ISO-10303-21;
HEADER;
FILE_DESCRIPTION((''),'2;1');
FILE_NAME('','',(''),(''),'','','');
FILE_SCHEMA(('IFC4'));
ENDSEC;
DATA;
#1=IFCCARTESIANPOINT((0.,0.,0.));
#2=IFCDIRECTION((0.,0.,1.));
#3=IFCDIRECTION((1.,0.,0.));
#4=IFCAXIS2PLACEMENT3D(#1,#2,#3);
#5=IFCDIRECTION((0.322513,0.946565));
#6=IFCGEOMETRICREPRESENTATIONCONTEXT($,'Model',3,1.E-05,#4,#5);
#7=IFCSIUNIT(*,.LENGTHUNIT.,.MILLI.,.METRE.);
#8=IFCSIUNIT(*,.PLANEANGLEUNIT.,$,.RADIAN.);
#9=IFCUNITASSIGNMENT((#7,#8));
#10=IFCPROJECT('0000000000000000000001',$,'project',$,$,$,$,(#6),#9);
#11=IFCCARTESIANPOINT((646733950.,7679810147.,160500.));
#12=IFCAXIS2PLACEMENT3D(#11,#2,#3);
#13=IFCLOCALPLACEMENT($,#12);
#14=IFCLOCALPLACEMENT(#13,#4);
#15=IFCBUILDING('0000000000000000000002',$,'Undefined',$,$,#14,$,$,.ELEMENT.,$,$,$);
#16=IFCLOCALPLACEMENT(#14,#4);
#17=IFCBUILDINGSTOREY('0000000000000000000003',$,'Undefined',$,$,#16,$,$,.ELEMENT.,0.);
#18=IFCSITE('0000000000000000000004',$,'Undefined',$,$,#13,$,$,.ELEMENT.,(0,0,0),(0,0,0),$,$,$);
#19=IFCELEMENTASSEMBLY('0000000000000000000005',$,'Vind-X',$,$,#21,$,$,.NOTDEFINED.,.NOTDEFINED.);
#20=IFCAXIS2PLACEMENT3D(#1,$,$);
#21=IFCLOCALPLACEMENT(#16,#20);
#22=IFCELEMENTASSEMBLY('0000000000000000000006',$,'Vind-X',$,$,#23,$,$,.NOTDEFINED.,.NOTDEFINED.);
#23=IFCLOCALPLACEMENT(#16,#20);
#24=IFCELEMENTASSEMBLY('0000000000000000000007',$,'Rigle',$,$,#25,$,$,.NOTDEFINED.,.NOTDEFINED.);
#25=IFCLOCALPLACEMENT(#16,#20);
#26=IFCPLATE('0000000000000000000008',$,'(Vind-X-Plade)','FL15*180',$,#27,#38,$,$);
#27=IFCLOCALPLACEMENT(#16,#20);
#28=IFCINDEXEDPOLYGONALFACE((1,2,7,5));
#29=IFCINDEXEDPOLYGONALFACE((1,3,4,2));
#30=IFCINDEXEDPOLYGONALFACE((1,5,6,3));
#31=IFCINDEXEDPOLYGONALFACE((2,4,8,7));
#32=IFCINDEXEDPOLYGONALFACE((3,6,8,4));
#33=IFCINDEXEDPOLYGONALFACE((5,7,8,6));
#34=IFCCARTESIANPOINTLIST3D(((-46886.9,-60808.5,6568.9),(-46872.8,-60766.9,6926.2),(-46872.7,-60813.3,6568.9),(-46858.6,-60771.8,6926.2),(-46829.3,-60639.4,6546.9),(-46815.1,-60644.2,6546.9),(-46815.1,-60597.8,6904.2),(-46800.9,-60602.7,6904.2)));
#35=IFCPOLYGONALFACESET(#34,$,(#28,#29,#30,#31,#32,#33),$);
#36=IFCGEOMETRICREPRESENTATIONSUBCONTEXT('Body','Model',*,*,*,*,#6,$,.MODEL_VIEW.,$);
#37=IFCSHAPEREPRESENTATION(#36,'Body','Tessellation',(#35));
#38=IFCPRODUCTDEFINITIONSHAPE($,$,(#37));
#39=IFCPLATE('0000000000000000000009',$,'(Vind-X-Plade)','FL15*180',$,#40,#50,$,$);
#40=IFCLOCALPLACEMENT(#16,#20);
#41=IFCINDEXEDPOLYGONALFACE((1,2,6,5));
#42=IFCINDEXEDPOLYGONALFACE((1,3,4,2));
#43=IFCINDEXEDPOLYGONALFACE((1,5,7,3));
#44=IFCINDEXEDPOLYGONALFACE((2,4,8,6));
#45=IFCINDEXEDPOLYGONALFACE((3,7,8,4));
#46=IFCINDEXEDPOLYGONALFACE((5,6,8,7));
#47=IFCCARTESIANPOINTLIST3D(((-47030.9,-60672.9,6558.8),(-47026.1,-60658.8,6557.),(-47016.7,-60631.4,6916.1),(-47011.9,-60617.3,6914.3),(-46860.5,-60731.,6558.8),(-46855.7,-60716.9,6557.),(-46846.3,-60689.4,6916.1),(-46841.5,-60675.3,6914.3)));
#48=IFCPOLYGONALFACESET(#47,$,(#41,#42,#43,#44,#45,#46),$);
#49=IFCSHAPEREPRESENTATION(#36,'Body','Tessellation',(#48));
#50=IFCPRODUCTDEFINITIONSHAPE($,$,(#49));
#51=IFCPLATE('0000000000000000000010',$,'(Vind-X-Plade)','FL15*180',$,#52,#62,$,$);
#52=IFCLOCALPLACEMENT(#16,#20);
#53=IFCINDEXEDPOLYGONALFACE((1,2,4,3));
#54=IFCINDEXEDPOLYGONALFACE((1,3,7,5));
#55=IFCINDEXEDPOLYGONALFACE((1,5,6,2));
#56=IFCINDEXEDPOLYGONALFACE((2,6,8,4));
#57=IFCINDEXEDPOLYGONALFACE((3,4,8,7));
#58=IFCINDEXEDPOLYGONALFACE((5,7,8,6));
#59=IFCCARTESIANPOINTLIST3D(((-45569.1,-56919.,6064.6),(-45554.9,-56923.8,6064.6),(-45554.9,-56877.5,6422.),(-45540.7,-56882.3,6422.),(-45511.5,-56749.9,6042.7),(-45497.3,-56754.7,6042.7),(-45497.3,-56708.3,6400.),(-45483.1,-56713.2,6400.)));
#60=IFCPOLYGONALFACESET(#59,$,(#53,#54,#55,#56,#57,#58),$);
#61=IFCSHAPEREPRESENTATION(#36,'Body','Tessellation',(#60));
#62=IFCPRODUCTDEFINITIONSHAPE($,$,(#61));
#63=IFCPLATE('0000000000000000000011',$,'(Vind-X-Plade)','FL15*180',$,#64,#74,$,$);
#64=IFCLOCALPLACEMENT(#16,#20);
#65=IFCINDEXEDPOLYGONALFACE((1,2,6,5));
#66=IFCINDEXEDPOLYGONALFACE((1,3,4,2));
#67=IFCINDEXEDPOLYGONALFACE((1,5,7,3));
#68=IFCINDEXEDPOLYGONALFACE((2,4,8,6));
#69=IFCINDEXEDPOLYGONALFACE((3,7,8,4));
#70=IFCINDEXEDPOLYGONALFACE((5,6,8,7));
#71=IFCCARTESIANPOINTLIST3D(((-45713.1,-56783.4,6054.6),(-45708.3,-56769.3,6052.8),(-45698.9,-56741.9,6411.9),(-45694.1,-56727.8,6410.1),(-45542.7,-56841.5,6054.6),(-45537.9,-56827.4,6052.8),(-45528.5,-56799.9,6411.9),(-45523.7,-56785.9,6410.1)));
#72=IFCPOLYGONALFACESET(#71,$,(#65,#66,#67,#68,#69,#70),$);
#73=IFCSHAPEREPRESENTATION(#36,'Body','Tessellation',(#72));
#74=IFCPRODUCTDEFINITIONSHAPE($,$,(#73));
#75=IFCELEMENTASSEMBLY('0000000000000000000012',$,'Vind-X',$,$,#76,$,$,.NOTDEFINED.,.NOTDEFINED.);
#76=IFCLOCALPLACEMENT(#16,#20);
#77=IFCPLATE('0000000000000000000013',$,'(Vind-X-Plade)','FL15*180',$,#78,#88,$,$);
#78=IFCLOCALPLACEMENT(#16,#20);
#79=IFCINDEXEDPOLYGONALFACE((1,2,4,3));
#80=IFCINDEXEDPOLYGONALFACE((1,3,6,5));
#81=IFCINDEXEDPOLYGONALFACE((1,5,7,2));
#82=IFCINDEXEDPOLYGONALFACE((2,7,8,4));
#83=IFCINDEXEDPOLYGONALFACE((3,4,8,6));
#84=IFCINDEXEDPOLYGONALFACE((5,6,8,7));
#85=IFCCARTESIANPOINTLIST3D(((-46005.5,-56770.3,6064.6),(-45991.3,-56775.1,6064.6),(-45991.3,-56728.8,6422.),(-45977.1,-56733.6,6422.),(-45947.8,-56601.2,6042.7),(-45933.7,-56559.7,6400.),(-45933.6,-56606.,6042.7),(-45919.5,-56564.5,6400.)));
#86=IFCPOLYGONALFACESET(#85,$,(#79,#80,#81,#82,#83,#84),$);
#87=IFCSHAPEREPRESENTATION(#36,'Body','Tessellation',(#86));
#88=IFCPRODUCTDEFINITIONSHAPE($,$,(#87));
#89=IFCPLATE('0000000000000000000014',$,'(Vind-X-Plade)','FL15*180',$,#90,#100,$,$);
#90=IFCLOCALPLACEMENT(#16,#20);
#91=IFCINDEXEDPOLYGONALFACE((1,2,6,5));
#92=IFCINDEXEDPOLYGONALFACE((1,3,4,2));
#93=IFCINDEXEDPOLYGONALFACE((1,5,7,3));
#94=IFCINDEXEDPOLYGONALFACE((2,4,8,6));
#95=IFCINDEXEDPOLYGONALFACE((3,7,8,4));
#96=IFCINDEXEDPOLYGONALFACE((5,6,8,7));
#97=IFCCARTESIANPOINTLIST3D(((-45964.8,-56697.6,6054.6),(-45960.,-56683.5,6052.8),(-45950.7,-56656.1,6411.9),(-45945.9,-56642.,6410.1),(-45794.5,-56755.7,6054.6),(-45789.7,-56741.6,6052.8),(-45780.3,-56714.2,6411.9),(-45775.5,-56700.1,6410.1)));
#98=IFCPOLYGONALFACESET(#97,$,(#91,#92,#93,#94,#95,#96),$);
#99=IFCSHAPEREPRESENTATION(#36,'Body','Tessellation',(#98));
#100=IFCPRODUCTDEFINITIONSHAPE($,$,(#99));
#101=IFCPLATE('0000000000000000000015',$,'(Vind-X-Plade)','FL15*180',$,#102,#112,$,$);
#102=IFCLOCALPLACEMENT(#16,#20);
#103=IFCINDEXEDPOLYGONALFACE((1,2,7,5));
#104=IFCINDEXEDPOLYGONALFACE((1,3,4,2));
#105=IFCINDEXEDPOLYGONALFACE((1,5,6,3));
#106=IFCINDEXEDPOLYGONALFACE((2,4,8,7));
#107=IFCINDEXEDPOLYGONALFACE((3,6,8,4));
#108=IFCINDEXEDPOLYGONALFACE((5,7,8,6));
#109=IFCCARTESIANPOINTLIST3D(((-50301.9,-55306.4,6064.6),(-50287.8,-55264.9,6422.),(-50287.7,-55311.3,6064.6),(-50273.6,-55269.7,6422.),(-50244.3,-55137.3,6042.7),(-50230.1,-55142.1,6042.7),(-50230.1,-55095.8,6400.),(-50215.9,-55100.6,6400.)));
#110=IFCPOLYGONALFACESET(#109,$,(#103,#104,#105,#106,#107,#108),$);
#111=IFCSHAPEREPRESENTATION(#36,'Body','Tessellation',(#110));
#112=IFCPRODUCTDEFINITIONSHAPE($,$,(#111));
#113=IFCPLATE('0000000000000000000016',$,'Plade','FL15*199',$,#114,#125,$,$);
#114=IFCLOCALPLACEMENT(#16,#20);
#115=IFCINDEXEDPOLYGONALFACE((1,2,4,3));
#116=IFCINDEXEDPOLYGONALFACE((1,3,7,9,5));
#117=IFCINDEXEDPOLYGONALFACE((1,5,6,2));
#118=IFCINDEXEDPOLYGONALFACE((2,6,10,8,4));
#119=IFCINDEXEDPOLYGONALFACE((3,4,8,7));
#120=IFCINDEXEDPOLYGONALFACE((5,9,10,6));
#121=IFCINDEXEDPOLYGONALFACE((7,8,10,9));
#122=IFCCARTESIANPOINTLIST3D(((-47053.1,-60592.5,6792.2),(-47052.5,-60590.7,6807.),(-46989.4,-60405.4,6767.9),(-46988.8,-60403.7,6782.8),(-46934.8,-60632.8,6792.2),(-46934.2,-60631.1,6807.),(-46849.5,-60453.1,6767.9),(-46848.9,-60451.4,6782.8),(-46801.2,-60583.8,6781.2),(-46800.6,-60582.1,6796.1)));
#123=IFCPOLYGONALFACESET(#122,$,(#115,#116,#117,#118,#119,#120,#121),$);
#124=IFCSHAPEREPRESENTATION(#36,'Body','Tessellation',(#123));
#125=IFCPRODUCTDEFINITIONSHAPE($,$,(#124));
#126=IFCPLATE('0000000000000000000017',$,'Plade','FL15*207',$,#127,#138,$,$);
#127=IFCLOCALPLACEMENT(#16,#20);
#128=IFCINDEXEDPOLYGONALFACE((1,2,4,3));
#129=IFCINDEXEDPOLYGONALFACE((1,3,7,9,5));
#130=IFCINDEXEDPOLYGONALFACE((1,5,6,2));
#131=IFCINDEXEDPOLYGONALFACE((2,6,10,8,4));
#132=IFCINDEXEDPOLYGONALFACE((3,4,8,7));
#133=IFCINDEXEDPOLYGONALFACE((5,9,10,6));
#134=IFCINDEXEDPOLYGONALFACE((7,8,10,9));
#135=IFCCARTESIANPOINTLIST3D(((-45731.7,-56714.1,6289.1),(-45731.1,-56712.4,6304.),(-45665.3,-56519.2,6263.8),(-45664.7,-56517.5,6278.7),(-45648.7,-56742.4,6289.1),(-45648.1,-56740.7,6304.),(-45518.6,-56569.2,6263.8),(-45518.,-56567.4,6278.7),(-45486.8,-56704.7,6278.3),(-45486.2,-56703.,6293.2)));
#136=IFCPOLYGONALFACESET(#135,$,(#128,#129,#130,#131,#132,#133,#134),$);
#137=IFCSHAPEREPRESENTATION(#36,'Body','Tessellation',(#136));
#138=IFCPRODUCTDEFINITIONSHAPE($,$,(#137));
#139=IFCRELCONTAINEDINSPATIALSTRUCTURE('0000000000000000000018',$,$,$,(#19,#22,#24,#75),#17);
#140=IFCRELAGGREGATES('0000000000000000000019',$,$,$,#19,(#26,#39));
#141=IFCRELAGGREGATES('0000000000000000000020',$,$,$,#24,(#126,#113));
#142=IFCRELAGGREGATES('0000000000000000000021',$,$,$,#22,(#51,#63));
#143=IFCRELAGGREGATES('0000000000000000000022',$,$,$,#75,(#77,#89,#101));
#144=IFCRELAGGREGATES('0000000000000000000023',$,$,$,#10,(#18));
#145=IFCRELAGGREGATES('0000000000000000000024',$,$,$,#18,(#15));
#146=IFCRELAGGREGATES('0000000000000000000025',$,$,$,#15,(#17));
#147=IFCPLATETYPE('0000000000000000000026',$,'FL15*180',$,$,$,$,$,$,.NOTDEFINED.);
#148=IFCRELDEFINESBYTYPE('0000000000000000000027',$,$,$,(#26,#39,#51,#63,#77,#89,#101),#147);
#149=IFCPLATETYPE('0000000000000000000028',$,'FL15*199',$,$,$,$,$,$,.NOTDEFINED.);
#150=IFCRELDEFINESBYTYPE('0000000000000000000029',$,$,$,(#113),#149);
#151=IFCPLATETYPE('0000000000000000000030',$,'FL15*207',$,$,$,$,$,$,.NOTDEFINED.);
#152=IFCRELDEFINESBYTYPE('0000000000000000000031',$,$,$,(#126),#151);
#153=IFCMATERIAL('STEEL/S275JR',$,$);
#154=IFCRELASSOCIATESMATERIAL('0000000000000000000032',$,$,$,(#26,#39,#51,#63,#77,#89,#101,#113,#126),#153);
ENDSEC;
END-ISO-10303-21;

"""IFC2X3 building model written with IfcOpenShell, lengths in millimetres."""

from ifc_helpers import new_model, si_unit, direction, frame, origin_with_axes, place, context, subcontext, project, spatial, polyline, outline, extrude, material, type_object, element, aggregate, save


model = new_model("IFC2X3")

# Units and contexts
model_context = context("Model", 3, precision=1e-05, world=origin_with_axes(), true_north=direction((0.322513, 0.946565)))
body_context = subcontext(model_context, "Body", "Model", "MODEL_VIEW")
ifc_project = project(units=[si_unit("LENGTHUNIT", "METRE", prefix="MILLI"), si_unit("PLANEANGLEUNIT", "RADIAN")], contexts=[model_context])

# Site, building, storey
site_placement = place(None, frame((646733950.0, 7679810147.0, 160500.0), z_axis=(0.0, 0.0, 1.0), x_axis=(1.0, 0.0, 0.0)))
site = spatial("IfcSite", under=ifc_project, at=site_placement, Name="Undefined", CompositionType="ELEMENT", RefLatitude=(0, 0, 0), RefLongitude=(0, 0, 0))
building_placement = place(site_placement, origin_with_axes())
building = spatial("IfcBuilding", under=site, at=building_placement, Name="Undefined", CompositionType="ELEMENT")
storey_placement = place(building_placement, origin_with_axes())
storey = spatial("IfcBuildingStorey", under=building, at=storey_placement, Name="Undefined", CompositionType="ELEMENT", Elevation=0.0)

# Element assemblies
assembly_1_placement = place(storey_placement, origin_with_axes())
assembly_1 = element("IfcElementAssembly", 1, at=assembly_1_placement, inside=storey, Name="Vind-X", AssemblyPlace="NOTDEFINED", PredefinedType="NOTDEFINED")
assembly_2_placement = place(storey_placement, origin_with_axes())
assembly_2 = element("IfcElementAssembly", 2, at=assembly_2_placement, inside=storey, Name="Vind-X", AssemblyPlace="NOTDEFINED", PredefinedType="NOTDEFINED")

# Element assembly
assembly_3_placement = place(storey_placement, origin_with_axes())
assembly_3 = element("IfcElementAssembly", 3, at=assembly_3_placement, inside=storey, Name="Rigle", AssemblyPlace="NOTDEFINED", PredefinedType="NOTDEFINED")

# Shared definitions
ifc_material_1 = material(Name="STEEL/S275JR")

# Plates
plate_type_1 = type_object("IfcPlateType", Name="FL15*180", PredefinedType="NOTDEFINED")
plate_1_placement = place(assembly_1_placement, frame((-46865.7, -60769.4, 6926.2), z_axis=(-0.946565, 0.322513, 0.0), x_axis=(0.320109, 0.93951, -0.121869)))
plate_1 = element("IfcPlate", 4, at=plate_1_placement, type_object=plate_type_1, material=ifc_material_1, Name="(Vind-X-Plade)", Description="FL15*180", context=body_context, shape_type="SweptSolid", body=[
    extrude(outline(polyline([(0.0, 0.0), (180.0, 0.0), (180.0, 360.0), (0.0, 360.0), (0.0, 0.0)])), frame((0.0, 0.0, -7.5), z_axis=(0.0, 0.0, 1.0), x_axis=(1.0, 0.0, 0.0)), (0.0, 0.0, 1.0), 15.0),
])
plate_2_placement = place(assembly_1_placement, frame((-47028.5, -60665.9, 6557.9), z_axis=(0.320109, 0.93951, -0.121869), x_axis=(0.039304, 0.115357, 0.992546)))
plate_2 = element("IfcPlate", 5, at=plate_2_placement, type_object=plate_type_1, material=ifc_material_1, Name="(Vind-X-Plade)", Description="FL15*180", context=body_context, shape_type="SweptSolid", body=[
    extrude(outline(polyline([(0.0, 0.0), (360.0, 0.0), (360.0, 180.0), (0.0, 180.0), (0.0, 0.0)])), frame((0.0, 0.0, -7.5), z_axis=(0.0, 0.0, 1.0), x_axis=(1.0, 0.0, 0.0)), (0.0, 0.0, 1.0), 15.0),
])
plate_3_placement = place(assembly_2_placement, frame((-45547.8, -56879.9, 6422.0), z_axis=(-0.946565, 0.322513, 0.0), x_axis=(0.320109, 0.93951, -0.121869)))
plate_3 = element("IfcPlate", 6, at=plate_3_placement, type_object=plate_type_1, material=ifc_material_1, Name="(Vind-X-Plade)", Description="FL15*180", context=body_context, shape_type="SweptSolid", body=[
    extrude(outline(polyline([(0.0, 0.0), (180.0, 0.0), (180.0, 360.0), (0.0, 360.0), (0.0, 0.0)])), frame((0.0, 0.0, -7.5), z_axis=(0.0, 0.0, 1.0), x_axis=(1.0, 0.0, 0.0)), (0.0, 0.0, 1.0), 15.0),
])
plate_4_placement = place(assembly_2_placement, frame((-45710.7, -56776.4, 6053.7), z_axis=(0.320109, 0.93951, -0.121869), x_axis=(0.039304, 0.115357, 0.992546)))
plate_4 = element("IfcPlate", 7, at=plate_4_placement, type_object=plate_type_1, material=ifc_material_1, Name="(Vind-X-Plade)", Description="FL15*180", context=body_context, shape_type="SweptSolid", body=[
    extrude(outline(polyline([(0.0, 0.0), (360.0, 0.0), (360.0, 180.0), (0.0, 180.0), (0.0, 0.0)])), frame((0.0, 0.0, -7.5), z_axis=(0.0, 0.0, 1.0), x_axis=(1.0, 0.0, 0.0)), (0.0, 0.0, 1.0), 15.0),
])

# Element assembly, plates
assembly_4_placement = place(storey_placement, origin_with_axes())
assembly_4 = element("IfcElementAssembly", 8, at=assembly_4_placement, inside=storey, Name="Vind-X", AssemblyPlace="NOTDEFINED", PredefinedType="NOTDEFINED")
plate_5_placement = place(assembly_4_placement, frame((-45926.6, -56562.1, 6400.0), z_axis=(0.946565, -0.322513, 0.0), x_axis=(-0.320109, -0.93951, 0.121869)))
plate_5 = element("IfcPlate", 9, at=plate_5_placement, type_object=plate_type_1, material=ifc_material_1, Name="(Vind-X-Plade)", Description="FL15*180", context=body_context, shape_type="SweptSolid", body=[
    extrude(outline(polyline([(0.0, 0.0), (180.0, 0.0), (180.0, 360.0), (0.0, 360.0), (0.0, 0.0)])), frame((0.0, 0.0, -7.5), z_axis=(0.0, 0.0, 1.0), x_axis=(1.0, 0.0, 0.0)), (0.0, 0.0, 1.0), 15.0),
])
plate_6_placement = place(assembly_4_placement, frame((-45792.1, -56748.6, 6053.7), z_axis=(-0.320109, -0.93951, 0.121869), x_axis=(0.039304, 0.115357, 0.992546)))
plate_6 = element("IfcPlate", 10, at=plate_6_placement, type_object=plate_type_1, material=ifc_material_1, Name="(Vind-X-Plade)", Description="FL15*180", context=body_context, shape_type="SweptSolid", body=[
    extrude(outline(polyline([(0.0, 0.0), (360.0, 0.0), (360.0, 180.0), (0.0, 180.0), (0.0, 0.0)])), frame((0.0, 0.0, -7.5), z_axis=(0.0, 0.0, 1.0), x_axis=(1.0, 0.0, 0.0)), (0.0, 0.0, 1.0), 15.0),
])
plate_7_placement = place(assembly_4_placement, frame((-50280.7, -55267.3, 6422.0), z_axis=(-0.946565, 0.322513, 0.0), x_axis=(0.320109, 0.93951, -0.121869)))
plate_7 = element("IfcPlate", 11, at=plate_7_placement, type_object=plate_type_1, material=ifc_material_1, Name="(Vind-X-Plade)", Description="FL15*180", context=body_context, shape_type="SweptSolid", body=[
    extrude(outline(polyline([(0.0, 0.0), (180.0, 0.0), (180.0, 360.0), (0.0, 360.0), (0.0, 0.0)])), frame((0.0, 0.0, -7.5), z_axis=(0.0, 0.0, 1.0), x_axis=(1.0, 0.0, 0.0)), (0.0, 0.0, 1.0), 15.0),
])

# Plates
plate_type_2 = type_object("IfcPlateType", Name="FL15*199", PredefinedType="NOTDEFINED")
plate_8_placement = place(assembly_3_placement, frame((-46989.1, -60404.6, 6775.3), z_axis=(0.039304, 0.115357, 0.992546), x_axis=(-0.320109, -0.93951, 0.121869)))
plate_8 = element("IfcPlate", 12, at=plate_8_placement, type_object=plate_type_2, material=ifc_material_1, Name="Plade", Description="FL15*199", context=body_context, shape_type="SweptSolid", body=[
    extrude(outline(polyline([(0.0, 0.0), (199.1, 0.0), (199.1, 125.0), (109.0, 235.7), (0.0, 147.8), (0.0, 0.0)])), frame((0.0, 0.0, -7.5), z_axis=(0.0, 0.0, 1.0), x_axis=(1.0, 0.0, 0.0)), (0.0, 0.0, 1.0), 15.0),
])
plate_type_3 = type_object("IfcPlateType", Name="FL15*207", PredefinedType="NOTDEFINED")
plate_9_placement = place(assembly_3_placement, frame((-45665.0, -56518.3, 6271.2), z_axis=(0.039304, 0.115357, 0.992546), x_axis=(-0.320109, -0.93951, 0.121869)))
plate_9 = element("IfcPlate", 13, at=plate_9_placement, type_object=plate_type_3, material=ifc_material_1, Name="Plade", Description="FL15*207", context=body_context, shape_type="SweptSolid", body=[
    extrude(outline(polyline([(0.0, 0.0), (207.5, 0.0), (207.5, 87.7), (118.9, 228.8), (0.0, 154.9), (0.0, 0.0)])), frame((0.0, 0.0, -7.5), z_axis=(0.0, 0.0, 1.0), x_axis=(1.0, 0.0, 0.0)), (0.0, 0.0, 1.0), 15.0),
])

aggregate(assembly_1, [plate_1, plate_2])
aggregate(assembly_3, [plate_9, plate_8])
aggregate(assembly_2, [plate_3, plate_4])
aggregate(assembly_4, [plate_5, plate_6, plate_7])

save(model, "model.ifc")
